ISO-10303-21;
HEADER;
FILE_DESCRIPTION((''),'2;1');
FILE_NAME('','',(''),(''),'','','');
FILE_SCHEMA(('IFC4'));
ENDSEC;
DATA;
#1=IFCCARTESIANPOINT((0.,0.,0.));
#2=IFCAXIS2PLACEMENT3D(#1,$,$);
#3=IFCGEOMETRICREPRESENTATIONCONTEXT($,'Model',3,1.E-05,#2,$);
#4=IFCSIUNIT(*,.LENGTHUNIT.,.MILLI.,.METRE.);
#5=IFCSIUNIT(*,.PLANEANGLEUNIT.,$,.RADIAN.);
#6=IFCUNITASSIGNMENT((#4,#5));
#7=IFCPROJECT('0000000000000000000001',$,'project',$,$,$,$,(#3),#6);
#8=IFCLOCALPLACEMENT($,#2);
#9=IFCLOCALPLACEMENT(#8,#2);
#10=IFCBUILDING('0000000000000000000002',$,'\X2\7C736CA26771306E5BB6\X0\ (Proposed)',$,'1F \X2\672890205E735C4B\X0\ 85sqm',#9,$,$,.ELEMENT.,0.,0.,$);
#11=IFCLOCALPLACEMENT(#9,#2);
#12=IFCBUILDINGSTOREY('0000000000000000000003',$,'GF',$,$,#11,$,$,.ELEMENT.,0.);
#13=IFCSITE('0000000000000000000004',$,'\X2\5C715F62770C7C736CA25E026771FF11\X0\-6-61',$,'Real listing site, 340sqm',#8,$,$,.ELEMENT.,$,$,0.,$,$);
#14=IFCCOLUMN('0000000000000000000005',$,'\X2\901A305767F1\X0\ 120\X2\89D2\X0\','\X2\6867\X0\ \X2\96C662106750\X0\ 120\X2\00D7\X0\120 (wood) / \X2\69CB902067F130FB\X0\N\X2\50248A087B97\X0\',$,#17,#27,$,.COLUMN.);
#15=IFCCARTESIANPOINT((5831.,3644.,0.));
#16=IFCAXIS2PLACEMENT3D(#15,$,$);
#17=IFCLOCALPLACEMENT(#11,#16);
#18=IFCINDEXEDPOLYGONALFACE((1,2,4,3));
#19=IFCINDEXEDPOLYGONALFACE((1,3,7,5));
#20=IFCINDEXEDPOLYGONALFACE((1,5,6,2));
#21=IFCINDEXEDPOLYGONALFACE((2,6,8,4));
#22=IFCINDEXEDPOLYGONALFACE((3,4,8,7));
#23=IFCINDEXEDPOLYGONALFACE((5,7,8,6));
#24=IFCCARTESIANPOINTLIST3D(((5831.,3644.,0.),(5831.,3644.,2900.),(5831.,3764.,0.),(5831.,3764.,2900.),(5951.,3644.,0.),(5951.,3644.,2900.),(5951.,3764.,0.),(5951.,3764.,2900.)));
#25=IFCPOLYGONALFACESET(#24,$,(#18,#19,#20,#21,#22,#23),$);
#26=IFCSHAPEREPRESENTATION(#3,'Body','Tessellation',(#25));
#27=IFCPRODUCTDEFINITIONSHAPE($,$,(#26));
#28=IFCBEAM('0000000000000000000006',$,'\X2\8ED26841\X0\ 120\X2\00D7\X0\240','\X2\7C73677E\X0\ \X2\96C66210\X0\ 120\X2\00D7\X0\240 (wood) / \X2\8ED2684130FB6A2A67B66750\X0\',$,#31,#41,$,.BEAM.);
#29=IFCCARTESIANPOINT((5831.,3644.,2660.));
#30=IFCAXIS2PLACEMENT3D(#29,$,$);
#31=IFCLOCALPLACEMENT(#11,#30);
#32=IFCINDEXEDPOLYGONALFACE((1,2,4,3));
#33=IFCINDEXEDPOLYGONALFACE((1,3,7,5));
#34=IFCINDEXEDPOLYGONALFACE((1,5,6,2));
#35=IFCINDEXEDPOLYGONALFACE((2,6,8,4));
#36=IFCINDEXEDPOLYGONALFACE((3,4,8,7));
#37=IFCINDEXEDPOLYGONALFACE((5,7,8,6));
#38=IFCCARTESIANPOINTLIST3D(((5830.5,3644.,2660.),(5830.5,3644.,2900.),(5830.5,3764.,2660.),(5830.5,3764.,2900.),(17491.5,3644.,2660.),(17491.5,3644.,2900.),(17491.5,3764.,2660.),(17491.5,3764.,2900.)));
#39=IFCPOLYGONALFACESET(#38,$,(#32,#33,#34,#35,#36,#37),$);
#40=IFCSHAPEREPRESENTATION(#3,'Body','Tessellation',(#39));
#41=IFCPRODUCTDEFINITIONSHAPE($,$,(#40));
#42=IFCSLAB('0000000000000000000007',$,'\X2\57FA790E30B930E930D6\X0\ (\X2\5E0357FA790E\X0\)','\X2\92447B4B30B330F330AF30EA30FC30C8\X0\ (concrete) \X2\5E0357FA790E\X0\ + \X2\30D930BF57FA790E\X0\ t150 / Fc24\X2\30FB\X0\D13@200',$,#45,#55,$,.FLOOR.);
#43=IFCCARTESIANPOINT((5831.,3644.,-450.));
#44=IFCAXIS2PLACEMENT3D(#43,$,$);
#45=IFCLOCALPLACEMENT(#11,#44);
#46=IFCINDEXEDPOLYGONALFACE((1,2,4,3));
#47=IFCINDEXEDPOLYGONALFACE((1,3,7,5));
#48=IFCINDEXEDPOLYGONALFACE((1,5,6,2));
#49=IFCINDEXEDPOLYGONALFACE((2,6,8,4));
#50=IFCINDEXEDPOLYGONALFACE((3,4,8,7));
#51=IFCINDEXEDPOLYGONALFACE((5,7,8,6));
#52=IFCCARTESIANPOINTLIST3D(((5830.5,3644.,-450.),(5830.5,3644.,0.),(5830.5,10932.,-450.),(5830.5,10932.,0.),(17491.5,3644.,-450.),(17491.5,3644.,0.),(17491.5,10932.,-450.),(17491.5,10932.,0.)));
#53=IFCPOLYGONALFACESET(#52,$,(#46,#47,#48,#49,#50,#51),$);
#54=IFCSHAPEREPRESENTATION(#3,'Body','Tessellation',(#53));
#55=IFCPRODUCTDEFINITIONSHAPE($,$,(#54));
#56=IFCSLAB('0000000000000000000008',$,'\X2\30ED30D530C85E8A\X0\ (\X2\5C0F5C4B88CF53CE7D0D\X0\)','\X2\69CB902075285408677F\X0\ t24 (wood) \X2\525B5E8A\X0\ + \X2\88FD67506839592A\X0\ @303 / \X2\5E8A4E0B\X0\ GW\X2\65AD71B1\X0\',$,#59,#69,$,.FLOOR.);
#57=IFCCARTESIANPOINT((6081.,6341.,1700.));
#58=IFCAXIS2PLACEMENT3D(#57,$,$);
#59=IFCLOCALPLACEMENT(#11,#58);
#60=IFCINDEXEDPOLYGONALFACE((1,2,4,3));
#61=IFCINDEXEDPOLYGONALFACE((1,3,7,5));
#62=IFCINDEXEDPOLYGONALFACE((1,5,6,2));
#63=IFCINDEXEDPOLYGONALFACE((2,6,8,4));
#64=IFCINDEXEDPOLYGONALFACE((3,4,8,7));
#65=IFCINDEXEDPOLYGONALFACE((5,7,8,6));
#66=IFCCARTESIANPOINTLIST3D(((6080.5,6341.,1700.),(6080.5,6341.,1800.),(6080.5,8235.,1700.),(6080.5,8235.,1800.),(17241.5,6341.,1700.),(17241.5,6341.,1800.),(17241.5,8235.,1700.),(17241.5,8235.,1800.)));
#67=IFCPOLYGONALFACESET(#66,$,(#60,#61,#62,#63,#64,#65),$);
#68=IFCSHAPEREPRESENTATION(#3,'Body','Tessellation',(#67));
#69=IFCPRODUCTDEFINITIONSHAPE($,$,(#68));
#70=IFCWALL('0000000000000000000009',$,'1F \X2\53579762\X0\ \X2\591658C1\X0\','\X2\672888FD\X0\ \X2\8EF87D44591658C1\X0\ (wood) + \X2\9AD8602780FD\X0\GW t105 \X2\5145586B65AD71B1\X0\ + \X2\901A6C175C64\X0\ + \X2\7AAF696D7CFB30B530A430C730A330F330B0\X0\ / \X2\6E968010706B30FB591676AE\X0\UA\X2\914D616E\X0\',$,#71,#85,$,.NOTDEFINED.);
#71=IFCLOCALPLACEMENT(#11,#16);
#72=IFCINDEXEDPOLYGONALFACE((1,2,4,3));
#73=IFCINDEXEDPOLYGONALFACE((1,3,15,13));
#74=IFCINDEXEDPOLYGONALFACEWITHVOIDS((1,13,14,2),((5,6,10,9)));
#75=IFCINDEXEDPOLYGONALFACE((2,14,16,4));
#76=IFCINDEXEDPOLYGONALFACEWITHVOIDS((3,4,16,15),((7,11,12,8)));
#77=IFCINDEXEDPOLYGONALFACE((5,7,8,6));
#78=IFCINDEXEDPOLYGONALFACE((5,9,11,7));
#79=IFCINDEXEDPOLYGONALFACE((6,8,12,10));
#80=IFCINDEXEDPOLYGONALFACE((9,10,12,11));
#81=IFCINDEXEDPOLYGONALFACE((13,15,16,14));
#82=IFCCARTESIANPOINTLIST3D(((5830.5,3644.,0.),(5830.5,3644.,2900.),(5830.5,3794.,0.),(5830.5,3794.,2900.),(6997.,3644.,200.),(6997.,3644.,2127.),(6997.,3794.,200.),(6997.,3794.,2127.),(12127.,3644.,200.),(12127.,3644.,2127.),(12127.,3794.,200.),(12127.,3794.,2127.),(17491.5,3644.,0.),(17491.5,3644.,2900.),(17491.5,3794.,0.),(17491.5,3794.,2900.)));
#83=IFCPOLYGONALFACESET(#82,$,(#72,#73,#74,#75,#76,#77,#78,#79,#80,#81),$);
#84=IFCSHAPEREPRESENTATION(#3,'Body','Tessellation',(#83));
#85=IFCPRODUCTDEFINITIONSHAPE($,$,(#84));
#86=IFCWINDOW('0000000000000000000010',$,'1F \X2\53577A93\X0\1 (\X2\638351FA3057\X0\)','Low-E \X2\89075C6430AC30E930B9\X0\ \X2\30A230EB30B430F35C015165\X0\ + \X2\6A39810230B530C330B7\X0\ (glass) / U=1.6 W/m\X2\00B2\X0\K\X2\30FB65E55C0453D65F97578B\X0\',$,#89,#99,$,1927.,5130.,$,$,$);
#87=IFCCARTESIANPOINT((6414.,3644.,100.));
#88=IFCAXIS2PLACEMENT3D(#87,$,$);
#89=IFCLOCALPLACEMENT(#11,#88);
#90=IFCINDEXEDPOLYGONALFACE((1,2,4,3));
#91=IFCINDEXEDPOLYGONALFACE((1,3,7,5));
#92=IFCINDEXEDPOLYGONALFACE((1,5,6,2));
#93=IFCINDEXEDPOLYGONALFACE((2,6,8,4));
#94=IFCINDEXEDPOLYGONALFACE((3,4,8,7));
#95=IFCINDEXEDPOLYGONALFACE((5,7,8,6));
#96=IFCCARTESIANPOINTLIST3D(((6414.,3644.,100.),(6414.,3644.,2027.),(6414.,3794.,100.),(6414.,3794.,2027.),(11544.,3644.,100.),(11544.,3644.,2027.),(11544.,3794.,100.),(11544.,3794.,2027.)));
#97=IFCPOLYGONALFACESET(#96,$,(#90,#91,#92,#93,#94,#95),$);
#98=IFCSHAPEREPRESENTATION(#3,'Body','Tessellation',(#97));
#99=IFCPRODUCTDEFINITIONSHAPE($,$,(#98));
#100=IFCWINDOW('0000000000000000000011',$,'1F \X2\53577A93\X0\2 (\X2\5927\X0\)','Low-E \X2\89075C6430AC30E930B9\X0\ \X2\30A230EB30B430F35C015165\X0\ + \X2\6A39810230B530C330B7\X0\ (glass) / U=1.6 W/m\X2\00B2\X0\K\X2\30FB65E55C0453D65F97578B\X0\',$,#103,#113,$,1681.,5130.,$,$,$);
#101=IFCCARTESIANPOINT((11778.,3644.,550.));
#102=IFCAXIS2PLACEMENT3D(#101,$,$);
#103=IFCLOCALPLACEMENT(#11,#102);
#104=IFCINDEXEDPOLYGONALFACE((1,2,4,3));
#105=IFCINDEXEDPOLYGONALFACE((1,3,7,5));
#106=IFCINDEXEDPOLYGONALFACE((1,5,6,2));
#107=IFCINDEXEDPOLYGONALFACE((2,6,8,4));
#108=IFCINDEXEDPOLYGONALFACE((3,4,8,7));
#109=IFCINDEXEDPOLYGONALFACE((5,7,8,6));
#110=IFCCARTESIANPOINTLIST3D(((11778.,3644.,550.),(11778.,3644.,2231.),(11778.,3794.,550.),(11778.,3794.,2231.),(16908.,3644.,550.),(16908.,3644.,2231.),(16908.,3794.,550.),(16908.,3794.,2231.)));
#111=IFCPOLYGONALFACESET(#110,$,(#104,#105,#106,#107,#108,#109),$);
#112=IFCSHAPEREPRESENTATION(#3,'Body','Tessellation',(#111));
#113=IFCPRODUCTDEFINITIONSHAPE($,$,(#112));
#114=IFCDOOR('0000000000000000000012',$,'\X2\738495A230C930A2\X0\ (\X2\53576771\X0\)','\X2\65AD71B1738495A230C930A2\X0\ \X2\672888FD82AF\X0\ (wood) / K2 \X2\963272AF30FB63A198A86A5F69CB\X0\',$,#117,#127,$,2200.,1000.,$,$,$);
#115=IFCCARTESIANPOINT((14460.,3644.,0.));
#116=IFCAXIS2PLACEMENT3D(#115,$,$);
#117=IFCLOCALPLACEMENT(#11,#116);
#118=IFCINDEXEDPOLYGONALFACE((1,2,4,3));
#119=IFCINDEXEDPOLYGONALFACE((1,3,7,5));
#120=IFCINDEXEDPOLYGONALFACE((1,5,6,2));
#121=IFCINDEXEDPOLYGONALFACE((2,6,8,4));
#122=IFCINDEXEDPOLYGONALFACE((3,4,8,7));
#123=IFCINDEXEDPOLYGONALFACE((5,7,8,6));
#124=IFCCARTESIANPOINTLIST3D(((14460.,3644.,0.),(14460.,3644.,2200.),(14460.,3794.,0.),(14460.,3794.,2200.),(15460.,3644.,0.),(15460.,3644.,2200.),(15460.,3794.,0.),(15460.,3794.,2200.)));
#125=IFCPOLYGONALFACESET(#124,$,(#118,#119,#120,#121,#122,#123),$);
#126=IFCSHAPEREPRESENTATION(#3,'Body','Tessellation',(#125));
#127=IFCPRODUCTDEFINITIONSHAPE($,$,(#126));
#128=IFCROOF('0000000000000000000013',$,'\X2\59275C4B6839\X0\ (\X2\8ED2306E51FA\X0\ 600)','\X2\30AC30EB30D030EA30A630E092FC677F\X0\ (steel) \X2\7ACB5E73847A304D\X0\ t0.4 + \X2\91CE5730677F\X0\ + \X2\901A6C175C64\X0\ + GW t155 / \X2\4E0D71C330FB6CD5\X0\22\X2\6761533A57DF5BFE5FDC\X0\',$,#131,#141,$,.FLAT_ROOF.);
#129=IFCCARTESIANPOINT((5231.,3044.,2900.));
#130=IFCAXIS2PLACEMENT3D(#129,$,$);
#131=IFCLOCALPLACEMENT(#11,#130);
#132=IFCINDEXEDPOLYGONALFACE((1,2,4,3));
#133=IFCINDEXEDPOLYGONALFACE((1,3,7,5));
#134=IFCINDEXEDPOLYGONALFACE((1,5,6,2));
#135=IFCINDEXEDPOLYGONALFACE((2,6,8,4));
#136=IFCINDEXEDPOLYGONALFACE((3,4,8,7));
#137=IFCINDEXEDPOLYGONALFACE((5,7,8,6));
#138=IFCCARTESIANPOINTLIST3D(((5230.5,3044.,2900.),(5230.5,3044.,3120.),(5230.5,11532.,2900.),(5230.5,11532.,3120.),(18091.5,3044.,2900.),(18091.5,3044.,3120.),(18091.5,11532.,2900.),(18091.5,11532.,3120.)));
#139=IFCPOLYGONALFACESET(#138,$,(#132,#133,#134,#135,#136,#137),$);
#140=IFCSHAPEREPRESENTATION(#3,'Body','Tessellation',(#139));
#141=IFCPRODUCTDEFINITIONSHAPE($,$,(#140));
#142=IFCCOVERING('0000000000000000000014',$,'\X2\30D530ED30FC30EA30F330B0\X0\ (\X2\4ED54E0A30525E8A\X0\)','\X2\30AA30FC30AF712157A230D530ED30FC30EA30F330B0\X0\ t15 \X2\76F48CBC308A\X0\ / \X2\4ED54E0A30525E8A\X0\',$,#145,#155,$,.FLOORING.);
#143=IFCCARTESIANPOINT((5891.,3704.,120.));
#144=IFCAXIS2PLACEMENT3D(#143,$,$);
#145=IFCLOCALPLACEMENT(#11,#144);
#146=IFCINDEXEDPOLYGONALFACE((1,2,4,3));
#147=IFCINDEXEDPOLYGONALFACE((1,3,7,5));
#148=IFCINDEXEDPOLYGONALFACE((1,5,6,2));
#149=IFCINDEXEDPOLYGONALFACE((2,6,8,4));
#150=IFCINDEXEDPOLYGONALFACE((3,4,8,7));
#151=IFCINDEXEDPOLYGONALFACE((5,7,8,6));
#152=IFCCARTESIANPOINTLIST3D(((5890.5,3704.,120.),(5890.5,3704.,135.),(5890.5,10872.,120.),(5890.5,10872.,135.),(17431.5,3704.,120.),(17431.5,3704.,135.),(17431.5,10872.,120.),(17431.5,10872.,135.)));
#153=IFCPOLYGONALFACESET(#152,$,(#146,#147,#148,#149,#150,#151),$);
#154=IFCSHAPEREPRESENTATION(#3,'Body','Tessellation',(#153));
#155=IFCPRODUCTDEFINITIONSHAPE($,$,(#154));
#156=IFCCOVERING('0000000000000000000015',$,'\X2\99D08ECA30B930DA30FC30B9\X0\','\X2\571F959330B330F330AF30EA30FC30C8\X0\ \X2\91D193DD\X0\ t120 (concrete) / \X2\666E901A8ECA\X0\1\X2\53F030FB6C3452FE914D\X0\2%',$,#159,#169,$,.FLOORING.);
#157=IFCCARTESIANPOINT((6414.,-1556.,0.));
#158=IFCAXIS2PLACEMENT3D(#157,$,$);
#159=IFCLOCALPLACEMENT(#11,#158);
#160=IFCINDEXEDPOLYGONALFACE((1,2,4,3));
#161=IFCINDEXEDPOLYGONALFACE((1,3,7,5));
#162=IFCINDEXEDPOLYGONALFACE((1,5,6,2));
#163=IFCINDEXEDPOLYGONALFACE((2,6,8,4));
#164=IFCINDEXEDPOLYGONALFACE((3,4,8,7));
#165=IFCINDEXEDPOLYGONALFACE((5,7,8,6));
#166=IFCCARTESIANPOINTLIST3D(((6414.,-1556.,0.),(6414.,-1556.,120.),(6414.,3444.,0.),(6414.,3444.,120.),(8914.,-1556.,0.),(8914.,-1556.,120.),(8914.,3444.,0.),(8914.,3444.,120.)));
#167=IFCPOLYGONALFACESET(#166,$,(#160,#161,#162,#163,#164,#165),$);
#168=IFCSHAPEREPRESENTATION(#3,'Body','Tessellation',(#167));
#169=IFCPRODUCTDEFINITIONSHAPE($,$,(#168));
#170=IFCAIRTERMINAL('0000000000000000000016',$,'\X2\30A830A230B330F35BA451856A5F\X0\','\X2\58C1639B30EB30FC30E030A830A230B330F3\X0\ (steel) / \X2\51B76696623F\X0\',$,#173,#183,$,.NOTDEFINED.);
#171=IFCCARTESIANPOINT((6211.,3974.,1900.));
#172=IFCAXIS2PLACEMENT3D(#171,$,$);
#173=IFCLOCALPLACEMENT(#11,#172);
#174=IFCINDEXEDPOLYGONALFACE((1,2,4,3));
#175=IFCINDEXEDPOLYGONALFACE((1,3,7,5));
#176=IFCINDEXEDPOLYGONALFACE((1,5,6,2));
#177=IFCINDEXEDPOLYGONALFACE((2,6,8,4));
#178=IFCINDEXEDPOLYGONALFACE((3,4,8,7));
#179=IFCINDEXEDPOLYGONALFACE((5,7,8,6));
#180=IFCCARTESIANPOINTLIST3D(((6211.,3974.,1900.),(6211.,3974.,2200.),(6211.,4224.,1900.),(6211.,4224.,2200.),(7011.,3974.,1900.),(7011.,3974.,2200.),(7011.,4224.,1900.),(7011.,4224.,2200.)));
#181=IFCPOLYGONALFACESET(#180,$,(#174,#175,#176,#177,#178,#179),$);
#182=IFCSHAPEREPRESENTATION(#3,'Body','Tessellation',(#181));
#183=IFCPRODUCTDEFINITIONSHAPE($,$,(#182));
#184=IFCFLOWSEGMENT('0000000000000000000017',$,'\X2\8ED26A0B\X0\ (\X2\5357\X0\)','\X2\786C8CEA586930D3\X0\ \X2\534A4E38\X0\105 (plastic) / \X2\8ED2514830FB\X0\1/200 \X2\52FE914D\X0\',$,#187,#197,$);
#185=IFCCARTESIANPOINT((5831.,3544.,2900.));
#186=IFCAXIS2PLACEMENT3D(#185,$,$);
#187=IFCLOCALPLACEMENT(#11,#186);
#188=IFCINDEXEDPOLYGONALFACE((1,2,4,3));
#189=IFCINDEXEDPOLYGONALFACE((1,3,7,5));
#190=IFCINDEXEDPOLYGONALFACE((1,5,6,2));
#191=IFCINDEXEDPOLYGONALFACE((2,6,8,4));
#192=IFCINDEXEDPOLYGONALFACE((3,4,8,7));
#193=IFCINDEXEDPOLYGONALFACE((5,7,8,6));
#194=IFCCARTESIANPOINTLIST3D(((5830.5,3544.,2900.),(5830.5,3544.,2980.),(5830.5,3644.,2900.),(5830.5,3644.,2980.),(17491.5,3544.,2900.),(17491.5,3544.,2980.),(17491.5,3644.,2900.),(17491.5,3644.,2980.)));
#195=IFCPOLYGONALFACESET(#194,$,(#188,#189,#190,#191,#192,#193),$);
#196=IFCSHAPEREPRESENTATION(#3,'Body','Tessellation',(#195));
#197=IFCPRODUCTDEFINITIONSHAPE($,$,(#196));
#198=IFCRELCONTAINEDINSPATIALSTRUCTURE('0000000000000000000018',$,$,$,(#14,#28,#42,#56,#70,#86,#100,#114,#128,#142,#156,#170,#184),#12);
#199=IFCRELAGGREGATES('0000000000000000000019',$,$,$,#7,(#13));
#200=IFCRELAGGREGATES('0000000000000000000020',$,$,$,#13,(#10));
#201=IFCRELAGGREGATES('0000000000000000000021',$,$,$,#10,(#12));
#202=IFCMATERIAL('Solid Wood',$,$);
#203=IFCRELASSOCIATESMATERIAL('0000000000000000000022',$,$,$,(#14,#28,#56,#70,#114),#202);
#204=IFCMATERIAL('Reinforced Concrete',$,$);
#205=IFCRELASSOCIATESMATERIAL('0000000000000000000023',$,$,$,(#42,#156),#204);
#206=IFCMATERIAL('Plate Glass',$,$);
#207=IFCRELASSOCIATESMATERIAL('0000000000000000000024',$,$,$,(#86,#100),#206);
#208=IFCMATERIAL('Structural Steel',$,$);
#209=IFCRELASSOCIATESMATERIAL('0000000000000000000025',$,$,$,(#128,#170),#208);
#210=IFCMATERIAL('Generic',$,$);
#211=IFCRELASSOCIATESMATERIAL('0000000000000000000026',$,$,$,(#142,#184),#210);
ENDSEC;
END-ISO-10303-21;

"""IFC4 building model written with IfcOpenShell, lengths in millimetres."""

from ifc_helpers import new_model, si_unit, frame, frame_2d, origin, place, context, project, spatial, rectangle, extrude, material, element, fill, save


model = new_model("IFC4")

# Units and contexts
model_context = context("Model", 3, precision=1e-05, world=origin())
ifc_project = project(units=[si_unit("LENGTHUNIT", "METRE", prefix="MILLI"), si_unit("PLANEANGLEUNIT", "RADIAN")], contexts=[model_context])

# Site, building, storey
site_placement = place(None, origin())
site = spatial("IfcSite", under=ifc_project, at=site_placement, Name="山形県米沢市東１-6-61", ObjectType="Real listing site, 340sqm", CompositionType="ELEMENT", RefElevation=0.0)
building_placement = place(site_placement, origin())
building = spatial("IfcBuilding", under=site, at=building_placement, Name="米沢東の家 (Proposed)", ObjectType="1F 木造平屋 85sqm", CompositionType="ELEMENT", ElevationOfRefHeight=0.0, ElevationOfTerrain=0.0)
storey_placement = place(building_placement, origin())
storey = spatial("IfcBuildingStorey", under=building, at=storey_placement, Name="GF", CompositionType="ELEMENT", Elevation=0.0)

# Column
ifc_material_1 = material(Name="Solid Wood")
column_1_placement = place(storey_placement, frame((5831.0, 3644.0, 0.0)))
element("IfcColumn", 1, at=column_1_placement, inside=storey, material=ifc_material_1, Name="通し柱 120角", Description="桧 集成材 120×120 (wood) / 構造柱・N値計算", PredefinedType="COLUMN", context=model_context, shape_type="SweptSolid", body=[
    extrude(rectangle(XDim=120.0, YDim=120.0, at=frame_2d((60.0, 60.0))), frame((5831.0, 3644.0, 0.0)), (0.0, 0.0, 1.0), 2900.0),
])

# Beam
beam_1_placement = place(storey_placement, frame((5831.0, 3644.0, 2660.0)))
element("IfcBeam", 2, at=beam_1_placement, inside=storey, material=ifc_material_1, Name="軒桁 120×240", Description="米松 集成 120×240 (wood) / 軒桁・横架材", PredefinedType="BEAM", context=model_context, shape_type="SweptSolid", body=[
    extrude(rectangle(XDim=11661.0, YDim=120.0, at=frame_2d((5830.0, 60.0))), frame((5831.0, 3644.0, 2660.0)), (0.0, 0.0, 1.0), 240.0),
])

# Slabs
ifc_material_2 = material(Name="Reinforced Concrete")
slab_1_placement = place(storey_placement, frame((5831.0, 3644.0, -450.0)))
element("IfcSlab", 3, at=slab_1_placement, inside=storey, material=ifc_material_2, Name="基礎スラブ (布基礎)", Description="鉄筋コンクリート (concrete) 布基礎 + ベタ基礎 t150 / Fc24・D13@200", PredefinedType="FLOOR", context=model_context, shape_type="SweptSolid", body=[
    extrude(rectangle(XDim=11661.0, YDim=7288.0, at=frame_2d((5830.0, 3644.0))), frame((5831.0, 3644.0, -450.0)), (0.0, 0.0, 1.0), 450.0),
])
slab_2_placement = place(storey_placement, frame((6081.0, 6341.0, 1700.0)))
element("IfcSlab", 4, at=slab_2_placement, inside=storey, material=ifc_material_1, Name="ロフト床 (小屋裏収納)", Description="構造用合板 t24 (wood) 剛床 + 製材根太 @303 / 床下 GW断熱", PredefinedType="FLOOR", context=model_context, shape_type="SweptSolid", body=[
    extrude(rectangle(XDim=11161.0, YDim=1894.0, at=frame_2d((5580.0, 947.0))), frame((6081.0, 6341.0, 1700.0)), (0.0, 0.0, 1.0), 100.0),
])

# Wall, openings, windows, door
wall_1_placement = place(storey_placement, frame((5831.0, 3644.0, 0.0)))
wall_1 = element("IfcWall", 5, at=wall_1_placement, inside=storey, material=ifc_material_1, Name="1F 南面 外壁", Description="木製 軸組外壁 (wood) + 高性能GW t105 充填断熱 + 通気層 + 窯業系サイディング / 準耐火・外皮UA配慮", PredefinedType="NOTDEFINED", context=model_context, shape_type="SweptSolid", body=[
    extrude(rectangle(XDim=11661.0, YDim=150.0, at=frame_2d((5830.0, 75.0))), frame((5831.0, 3644.0, 0.0)), (0.0, 0.0, 1.0), 2900.0),
])
opening_1_placement = place(storey_placement, frame((6414.0, 3644.0, 100.0)))
opening_1 = element("IfcOpeningElement", 6, at=opening_1_placement, cuts=wall_1, PredefinedType="NOTDEFINED", context=model_context, shape_type="SweptSolid", body=[
    extrude(rectangle(XDim=5130.0, YDim=150.0, at=frame_2d((2565.0, 75.0))), frame((6414.0, 3644.0, 100.0)), (0.0, 0.0, 1.0), 1927.0),
])
opening_2_placement = place(storey_placement, frame((11778.0, 3644.0, 550.0)))
opening_2 = element("IfcOpeningElement", 7, at=opening_2_placement, cuts=wall_1, PredefinedType="NOTDEFINED", context=model_context, shape_type="SweptSolid", body=[
    extrude(rectangle(XDim=5130.0, YDim=150.0, at=frame_2d((2565.0, 75.0))), frame((11778.0, 3644.0, 550.0)), (0.0, 0.0, 1.0), 1681.0),
])
opening_3_placement = place(storey_placement, frame((14460.0, 3644.0, 0.0)))
opening_3 = element("IfcOpeningElement", 8, at=opening_3_placement, cuts=wall_1, PredefinedType="NOTDEFINED", context=model_context, shape_type="SweptSolid", body=[
    extrude(rectangle(XDim=1000.0, YDim=150.0, at=frame_2d((500.0, 75.0))), frame((14460.0, 3644.0, 0.0)), (0.0, 0.0, 1.0), 2200.0),
])
ifc_material_3 = material(Name="Plate Glass")
window_1_placement = place(storey_placement, frame((6414.0, 3644.0, 100.0)))
window_1 = element("IfcWindow", 9, at=window_1_placement, inside=storey, material=ifc_material_3, Name="1F 南窓1 (掃出し)", Description="Low-E 複層ガラス アルゴン封入 + 樹脂サッシ (glass) / U=1.6 W/m²K・日射取得型", OverallHeight=1927.0, OverallWidth=5130.0, context=model_context, shape_type="SweptSolid", body=[
    extrude(rectangle(XDim=5130.0, YDim=150.0, at=frame_2d((2565.0, 75.0))), frame((6414.0, 3644.0, 100.0)), (0.0, 0.0, 1.0), 1927.0),
])
fill(opening_1, window_1)
window_2_placement = place(storey_placement, frame((11778.0, 3644.0, 550.0)))
window_2 = element("IfcWindow", 10, at=window_2_placement, inside=storey, material=ifc_material_3, Name="1F 南窓2 (大)", Description="Low-E 複層ガラス アルゴン封入 + 樹脂サッシ (glass) / U=1.6 W/m²K・日射取得型", OverallHeight=1681.0, OverallWidth=5130.0, context=model_context, shape_type="SweptSolid", body=[
    extrude(rectangle(XDim=5130.0, YDim=150.0, at=frame_2d((2565.0, 75.0))), frame((11778.0, 3644.0, 550.0)), (0.0, 0.0, 1.0), 1681.0),
])
fill(opening_2, window_2)
door_placement = place(storey_placement, frame((14460.0, 3644.0, 0.0)))
door = element("IfcDoor", 11, at=door_placement, inside=storey, material=ifc_material_1, Name="玄関ドア (南東)", Description="断熱玄関ドア 木製芯 (wood) / K2 防犯・採風機構", OverallHeight=2200.0, OverallWidth=1000.0, context=model_context, shape_type="SweptSolid", body=[
    extrude(rectangle(XDim=1000.0, YDim=150.0, at=frame_2d((500.0, 75.0))), frame((14460.0, 3644.0, 0.0)), (0.0, 0.0, 1.0), 2200.0),
])
fill(opening_3, door)

# Roof
ifc_material_4 = material(Name="Structural Steel")
roof_placement = place(storey_placement, frame((5231.0, 3044.0, 2900.0)))
element("IfcRoof", 12, at=roof_placement, inside=storey, material=ifc_material_4, Name="大屋根 (軒の出 600)", Description="ガルバリウム鋼板 (steel) 立平葺き t0.4 + 野地板 + 通気層 + GW t155 / 不燃・法22条区域対応", PredefinedType="FLAT_ROOF", context=model_context, shape_type="SweptSolid", body=[
    extrude(rectangle(XDim=12861.0, YDim=8488.0, at=frame_2d((6430.0, 4244.0))), frame((5231.0, 3044.0, 2900.0)), (0.0, 0.0, 1.0), 220.0),
])

# Coverings
ifc_material_5 = material(Name="Generic")
covering_1_placement = place(storey_placement, frame((5891.0, 3704.0, 120.0)))
element("IfcCovering", 13, at=covering_1_placement, inside=storey, material=ifc_material_5, Name="フローリング (仕上げ床)", Description="オーク無垢フローリング t15 直貼り / 仕上げ床", PredefinedType="FLOORING", context=model_context, shape_type="SweptSolid", body=[
    extrude(rectangle(XDim=11541.0, YDim=7168.0, at=frame_2d((5770.0, 3584.0))), frame((5891.0, 3704.0, 120.0)), (0.0, 0.0, 1.0), 15.0),
])
covering_2_placement = place(storey_placement, frame((6414.0, -1556.0, 0.0)))
element("IfcCovering", 14, at=covering_2_placement, inside=storey, material=ifc_material_2, Name="駐車スペース", Description="土間コンクリート 金鏝 t120 (concrete) / 普通車1台・水勾配2%", PredefinedType="FLOORING", context=model_context, shape_type="SweptSolid", body=[
    extrude(rectangle(XDim=2500.0, YDim=5000.0, at=frame_2d((1250.0, 2500.0))), frame((6414.0, -1556.0, 0.0)), (0.0, 0.0, 1.0), 120.0),
])

# Air terminal
air_terminal_placement = place(storey_placement, frame((6211.0, 3974.0, 1900.0)))
element("IfcAirTerminal", 15, at=air_terminal_placement, inside=storey, material=ifc_material_4, Name="エアコン室内機", Description="壁掛ルームエアコン (steel) / 冷暖房", PredefinedType="NOTDEFINED", context=model_context, shape_type="SweptSolid", body=[
    extrude(rectangle(XDim=800.0, YDim=250.0, at=frame_2d((400.0, 125.0))), frame((6211.0, 3974.0, 1900.0)), (0.0, 0.0, 1.0), 300.0),
])

# Flow segment
flow_segment_1_placement = place(storey_placement, frame((5831.0, 3544.0, 2900.0)))
element("IfcFlowSegment", 16, at=flow_segment_1_placement, inside=storey, material=ifc_material_5, Name="軒樋 (南)", Description="硬質塩ビ 半丸105 (plastic) / 軒先・1/200 勾配", context=model_context, shape_type="SweptSolid", body=[
    extrude(rectangle(XDim=11661.0, YDim=100.0, at=frame_2d((5830.0, 50.0))), frame((5831.0, 3544.0, 2900.0)), (0.0, 0.0, 1.0), 80.0),
])

save(model, "model.ifc")
